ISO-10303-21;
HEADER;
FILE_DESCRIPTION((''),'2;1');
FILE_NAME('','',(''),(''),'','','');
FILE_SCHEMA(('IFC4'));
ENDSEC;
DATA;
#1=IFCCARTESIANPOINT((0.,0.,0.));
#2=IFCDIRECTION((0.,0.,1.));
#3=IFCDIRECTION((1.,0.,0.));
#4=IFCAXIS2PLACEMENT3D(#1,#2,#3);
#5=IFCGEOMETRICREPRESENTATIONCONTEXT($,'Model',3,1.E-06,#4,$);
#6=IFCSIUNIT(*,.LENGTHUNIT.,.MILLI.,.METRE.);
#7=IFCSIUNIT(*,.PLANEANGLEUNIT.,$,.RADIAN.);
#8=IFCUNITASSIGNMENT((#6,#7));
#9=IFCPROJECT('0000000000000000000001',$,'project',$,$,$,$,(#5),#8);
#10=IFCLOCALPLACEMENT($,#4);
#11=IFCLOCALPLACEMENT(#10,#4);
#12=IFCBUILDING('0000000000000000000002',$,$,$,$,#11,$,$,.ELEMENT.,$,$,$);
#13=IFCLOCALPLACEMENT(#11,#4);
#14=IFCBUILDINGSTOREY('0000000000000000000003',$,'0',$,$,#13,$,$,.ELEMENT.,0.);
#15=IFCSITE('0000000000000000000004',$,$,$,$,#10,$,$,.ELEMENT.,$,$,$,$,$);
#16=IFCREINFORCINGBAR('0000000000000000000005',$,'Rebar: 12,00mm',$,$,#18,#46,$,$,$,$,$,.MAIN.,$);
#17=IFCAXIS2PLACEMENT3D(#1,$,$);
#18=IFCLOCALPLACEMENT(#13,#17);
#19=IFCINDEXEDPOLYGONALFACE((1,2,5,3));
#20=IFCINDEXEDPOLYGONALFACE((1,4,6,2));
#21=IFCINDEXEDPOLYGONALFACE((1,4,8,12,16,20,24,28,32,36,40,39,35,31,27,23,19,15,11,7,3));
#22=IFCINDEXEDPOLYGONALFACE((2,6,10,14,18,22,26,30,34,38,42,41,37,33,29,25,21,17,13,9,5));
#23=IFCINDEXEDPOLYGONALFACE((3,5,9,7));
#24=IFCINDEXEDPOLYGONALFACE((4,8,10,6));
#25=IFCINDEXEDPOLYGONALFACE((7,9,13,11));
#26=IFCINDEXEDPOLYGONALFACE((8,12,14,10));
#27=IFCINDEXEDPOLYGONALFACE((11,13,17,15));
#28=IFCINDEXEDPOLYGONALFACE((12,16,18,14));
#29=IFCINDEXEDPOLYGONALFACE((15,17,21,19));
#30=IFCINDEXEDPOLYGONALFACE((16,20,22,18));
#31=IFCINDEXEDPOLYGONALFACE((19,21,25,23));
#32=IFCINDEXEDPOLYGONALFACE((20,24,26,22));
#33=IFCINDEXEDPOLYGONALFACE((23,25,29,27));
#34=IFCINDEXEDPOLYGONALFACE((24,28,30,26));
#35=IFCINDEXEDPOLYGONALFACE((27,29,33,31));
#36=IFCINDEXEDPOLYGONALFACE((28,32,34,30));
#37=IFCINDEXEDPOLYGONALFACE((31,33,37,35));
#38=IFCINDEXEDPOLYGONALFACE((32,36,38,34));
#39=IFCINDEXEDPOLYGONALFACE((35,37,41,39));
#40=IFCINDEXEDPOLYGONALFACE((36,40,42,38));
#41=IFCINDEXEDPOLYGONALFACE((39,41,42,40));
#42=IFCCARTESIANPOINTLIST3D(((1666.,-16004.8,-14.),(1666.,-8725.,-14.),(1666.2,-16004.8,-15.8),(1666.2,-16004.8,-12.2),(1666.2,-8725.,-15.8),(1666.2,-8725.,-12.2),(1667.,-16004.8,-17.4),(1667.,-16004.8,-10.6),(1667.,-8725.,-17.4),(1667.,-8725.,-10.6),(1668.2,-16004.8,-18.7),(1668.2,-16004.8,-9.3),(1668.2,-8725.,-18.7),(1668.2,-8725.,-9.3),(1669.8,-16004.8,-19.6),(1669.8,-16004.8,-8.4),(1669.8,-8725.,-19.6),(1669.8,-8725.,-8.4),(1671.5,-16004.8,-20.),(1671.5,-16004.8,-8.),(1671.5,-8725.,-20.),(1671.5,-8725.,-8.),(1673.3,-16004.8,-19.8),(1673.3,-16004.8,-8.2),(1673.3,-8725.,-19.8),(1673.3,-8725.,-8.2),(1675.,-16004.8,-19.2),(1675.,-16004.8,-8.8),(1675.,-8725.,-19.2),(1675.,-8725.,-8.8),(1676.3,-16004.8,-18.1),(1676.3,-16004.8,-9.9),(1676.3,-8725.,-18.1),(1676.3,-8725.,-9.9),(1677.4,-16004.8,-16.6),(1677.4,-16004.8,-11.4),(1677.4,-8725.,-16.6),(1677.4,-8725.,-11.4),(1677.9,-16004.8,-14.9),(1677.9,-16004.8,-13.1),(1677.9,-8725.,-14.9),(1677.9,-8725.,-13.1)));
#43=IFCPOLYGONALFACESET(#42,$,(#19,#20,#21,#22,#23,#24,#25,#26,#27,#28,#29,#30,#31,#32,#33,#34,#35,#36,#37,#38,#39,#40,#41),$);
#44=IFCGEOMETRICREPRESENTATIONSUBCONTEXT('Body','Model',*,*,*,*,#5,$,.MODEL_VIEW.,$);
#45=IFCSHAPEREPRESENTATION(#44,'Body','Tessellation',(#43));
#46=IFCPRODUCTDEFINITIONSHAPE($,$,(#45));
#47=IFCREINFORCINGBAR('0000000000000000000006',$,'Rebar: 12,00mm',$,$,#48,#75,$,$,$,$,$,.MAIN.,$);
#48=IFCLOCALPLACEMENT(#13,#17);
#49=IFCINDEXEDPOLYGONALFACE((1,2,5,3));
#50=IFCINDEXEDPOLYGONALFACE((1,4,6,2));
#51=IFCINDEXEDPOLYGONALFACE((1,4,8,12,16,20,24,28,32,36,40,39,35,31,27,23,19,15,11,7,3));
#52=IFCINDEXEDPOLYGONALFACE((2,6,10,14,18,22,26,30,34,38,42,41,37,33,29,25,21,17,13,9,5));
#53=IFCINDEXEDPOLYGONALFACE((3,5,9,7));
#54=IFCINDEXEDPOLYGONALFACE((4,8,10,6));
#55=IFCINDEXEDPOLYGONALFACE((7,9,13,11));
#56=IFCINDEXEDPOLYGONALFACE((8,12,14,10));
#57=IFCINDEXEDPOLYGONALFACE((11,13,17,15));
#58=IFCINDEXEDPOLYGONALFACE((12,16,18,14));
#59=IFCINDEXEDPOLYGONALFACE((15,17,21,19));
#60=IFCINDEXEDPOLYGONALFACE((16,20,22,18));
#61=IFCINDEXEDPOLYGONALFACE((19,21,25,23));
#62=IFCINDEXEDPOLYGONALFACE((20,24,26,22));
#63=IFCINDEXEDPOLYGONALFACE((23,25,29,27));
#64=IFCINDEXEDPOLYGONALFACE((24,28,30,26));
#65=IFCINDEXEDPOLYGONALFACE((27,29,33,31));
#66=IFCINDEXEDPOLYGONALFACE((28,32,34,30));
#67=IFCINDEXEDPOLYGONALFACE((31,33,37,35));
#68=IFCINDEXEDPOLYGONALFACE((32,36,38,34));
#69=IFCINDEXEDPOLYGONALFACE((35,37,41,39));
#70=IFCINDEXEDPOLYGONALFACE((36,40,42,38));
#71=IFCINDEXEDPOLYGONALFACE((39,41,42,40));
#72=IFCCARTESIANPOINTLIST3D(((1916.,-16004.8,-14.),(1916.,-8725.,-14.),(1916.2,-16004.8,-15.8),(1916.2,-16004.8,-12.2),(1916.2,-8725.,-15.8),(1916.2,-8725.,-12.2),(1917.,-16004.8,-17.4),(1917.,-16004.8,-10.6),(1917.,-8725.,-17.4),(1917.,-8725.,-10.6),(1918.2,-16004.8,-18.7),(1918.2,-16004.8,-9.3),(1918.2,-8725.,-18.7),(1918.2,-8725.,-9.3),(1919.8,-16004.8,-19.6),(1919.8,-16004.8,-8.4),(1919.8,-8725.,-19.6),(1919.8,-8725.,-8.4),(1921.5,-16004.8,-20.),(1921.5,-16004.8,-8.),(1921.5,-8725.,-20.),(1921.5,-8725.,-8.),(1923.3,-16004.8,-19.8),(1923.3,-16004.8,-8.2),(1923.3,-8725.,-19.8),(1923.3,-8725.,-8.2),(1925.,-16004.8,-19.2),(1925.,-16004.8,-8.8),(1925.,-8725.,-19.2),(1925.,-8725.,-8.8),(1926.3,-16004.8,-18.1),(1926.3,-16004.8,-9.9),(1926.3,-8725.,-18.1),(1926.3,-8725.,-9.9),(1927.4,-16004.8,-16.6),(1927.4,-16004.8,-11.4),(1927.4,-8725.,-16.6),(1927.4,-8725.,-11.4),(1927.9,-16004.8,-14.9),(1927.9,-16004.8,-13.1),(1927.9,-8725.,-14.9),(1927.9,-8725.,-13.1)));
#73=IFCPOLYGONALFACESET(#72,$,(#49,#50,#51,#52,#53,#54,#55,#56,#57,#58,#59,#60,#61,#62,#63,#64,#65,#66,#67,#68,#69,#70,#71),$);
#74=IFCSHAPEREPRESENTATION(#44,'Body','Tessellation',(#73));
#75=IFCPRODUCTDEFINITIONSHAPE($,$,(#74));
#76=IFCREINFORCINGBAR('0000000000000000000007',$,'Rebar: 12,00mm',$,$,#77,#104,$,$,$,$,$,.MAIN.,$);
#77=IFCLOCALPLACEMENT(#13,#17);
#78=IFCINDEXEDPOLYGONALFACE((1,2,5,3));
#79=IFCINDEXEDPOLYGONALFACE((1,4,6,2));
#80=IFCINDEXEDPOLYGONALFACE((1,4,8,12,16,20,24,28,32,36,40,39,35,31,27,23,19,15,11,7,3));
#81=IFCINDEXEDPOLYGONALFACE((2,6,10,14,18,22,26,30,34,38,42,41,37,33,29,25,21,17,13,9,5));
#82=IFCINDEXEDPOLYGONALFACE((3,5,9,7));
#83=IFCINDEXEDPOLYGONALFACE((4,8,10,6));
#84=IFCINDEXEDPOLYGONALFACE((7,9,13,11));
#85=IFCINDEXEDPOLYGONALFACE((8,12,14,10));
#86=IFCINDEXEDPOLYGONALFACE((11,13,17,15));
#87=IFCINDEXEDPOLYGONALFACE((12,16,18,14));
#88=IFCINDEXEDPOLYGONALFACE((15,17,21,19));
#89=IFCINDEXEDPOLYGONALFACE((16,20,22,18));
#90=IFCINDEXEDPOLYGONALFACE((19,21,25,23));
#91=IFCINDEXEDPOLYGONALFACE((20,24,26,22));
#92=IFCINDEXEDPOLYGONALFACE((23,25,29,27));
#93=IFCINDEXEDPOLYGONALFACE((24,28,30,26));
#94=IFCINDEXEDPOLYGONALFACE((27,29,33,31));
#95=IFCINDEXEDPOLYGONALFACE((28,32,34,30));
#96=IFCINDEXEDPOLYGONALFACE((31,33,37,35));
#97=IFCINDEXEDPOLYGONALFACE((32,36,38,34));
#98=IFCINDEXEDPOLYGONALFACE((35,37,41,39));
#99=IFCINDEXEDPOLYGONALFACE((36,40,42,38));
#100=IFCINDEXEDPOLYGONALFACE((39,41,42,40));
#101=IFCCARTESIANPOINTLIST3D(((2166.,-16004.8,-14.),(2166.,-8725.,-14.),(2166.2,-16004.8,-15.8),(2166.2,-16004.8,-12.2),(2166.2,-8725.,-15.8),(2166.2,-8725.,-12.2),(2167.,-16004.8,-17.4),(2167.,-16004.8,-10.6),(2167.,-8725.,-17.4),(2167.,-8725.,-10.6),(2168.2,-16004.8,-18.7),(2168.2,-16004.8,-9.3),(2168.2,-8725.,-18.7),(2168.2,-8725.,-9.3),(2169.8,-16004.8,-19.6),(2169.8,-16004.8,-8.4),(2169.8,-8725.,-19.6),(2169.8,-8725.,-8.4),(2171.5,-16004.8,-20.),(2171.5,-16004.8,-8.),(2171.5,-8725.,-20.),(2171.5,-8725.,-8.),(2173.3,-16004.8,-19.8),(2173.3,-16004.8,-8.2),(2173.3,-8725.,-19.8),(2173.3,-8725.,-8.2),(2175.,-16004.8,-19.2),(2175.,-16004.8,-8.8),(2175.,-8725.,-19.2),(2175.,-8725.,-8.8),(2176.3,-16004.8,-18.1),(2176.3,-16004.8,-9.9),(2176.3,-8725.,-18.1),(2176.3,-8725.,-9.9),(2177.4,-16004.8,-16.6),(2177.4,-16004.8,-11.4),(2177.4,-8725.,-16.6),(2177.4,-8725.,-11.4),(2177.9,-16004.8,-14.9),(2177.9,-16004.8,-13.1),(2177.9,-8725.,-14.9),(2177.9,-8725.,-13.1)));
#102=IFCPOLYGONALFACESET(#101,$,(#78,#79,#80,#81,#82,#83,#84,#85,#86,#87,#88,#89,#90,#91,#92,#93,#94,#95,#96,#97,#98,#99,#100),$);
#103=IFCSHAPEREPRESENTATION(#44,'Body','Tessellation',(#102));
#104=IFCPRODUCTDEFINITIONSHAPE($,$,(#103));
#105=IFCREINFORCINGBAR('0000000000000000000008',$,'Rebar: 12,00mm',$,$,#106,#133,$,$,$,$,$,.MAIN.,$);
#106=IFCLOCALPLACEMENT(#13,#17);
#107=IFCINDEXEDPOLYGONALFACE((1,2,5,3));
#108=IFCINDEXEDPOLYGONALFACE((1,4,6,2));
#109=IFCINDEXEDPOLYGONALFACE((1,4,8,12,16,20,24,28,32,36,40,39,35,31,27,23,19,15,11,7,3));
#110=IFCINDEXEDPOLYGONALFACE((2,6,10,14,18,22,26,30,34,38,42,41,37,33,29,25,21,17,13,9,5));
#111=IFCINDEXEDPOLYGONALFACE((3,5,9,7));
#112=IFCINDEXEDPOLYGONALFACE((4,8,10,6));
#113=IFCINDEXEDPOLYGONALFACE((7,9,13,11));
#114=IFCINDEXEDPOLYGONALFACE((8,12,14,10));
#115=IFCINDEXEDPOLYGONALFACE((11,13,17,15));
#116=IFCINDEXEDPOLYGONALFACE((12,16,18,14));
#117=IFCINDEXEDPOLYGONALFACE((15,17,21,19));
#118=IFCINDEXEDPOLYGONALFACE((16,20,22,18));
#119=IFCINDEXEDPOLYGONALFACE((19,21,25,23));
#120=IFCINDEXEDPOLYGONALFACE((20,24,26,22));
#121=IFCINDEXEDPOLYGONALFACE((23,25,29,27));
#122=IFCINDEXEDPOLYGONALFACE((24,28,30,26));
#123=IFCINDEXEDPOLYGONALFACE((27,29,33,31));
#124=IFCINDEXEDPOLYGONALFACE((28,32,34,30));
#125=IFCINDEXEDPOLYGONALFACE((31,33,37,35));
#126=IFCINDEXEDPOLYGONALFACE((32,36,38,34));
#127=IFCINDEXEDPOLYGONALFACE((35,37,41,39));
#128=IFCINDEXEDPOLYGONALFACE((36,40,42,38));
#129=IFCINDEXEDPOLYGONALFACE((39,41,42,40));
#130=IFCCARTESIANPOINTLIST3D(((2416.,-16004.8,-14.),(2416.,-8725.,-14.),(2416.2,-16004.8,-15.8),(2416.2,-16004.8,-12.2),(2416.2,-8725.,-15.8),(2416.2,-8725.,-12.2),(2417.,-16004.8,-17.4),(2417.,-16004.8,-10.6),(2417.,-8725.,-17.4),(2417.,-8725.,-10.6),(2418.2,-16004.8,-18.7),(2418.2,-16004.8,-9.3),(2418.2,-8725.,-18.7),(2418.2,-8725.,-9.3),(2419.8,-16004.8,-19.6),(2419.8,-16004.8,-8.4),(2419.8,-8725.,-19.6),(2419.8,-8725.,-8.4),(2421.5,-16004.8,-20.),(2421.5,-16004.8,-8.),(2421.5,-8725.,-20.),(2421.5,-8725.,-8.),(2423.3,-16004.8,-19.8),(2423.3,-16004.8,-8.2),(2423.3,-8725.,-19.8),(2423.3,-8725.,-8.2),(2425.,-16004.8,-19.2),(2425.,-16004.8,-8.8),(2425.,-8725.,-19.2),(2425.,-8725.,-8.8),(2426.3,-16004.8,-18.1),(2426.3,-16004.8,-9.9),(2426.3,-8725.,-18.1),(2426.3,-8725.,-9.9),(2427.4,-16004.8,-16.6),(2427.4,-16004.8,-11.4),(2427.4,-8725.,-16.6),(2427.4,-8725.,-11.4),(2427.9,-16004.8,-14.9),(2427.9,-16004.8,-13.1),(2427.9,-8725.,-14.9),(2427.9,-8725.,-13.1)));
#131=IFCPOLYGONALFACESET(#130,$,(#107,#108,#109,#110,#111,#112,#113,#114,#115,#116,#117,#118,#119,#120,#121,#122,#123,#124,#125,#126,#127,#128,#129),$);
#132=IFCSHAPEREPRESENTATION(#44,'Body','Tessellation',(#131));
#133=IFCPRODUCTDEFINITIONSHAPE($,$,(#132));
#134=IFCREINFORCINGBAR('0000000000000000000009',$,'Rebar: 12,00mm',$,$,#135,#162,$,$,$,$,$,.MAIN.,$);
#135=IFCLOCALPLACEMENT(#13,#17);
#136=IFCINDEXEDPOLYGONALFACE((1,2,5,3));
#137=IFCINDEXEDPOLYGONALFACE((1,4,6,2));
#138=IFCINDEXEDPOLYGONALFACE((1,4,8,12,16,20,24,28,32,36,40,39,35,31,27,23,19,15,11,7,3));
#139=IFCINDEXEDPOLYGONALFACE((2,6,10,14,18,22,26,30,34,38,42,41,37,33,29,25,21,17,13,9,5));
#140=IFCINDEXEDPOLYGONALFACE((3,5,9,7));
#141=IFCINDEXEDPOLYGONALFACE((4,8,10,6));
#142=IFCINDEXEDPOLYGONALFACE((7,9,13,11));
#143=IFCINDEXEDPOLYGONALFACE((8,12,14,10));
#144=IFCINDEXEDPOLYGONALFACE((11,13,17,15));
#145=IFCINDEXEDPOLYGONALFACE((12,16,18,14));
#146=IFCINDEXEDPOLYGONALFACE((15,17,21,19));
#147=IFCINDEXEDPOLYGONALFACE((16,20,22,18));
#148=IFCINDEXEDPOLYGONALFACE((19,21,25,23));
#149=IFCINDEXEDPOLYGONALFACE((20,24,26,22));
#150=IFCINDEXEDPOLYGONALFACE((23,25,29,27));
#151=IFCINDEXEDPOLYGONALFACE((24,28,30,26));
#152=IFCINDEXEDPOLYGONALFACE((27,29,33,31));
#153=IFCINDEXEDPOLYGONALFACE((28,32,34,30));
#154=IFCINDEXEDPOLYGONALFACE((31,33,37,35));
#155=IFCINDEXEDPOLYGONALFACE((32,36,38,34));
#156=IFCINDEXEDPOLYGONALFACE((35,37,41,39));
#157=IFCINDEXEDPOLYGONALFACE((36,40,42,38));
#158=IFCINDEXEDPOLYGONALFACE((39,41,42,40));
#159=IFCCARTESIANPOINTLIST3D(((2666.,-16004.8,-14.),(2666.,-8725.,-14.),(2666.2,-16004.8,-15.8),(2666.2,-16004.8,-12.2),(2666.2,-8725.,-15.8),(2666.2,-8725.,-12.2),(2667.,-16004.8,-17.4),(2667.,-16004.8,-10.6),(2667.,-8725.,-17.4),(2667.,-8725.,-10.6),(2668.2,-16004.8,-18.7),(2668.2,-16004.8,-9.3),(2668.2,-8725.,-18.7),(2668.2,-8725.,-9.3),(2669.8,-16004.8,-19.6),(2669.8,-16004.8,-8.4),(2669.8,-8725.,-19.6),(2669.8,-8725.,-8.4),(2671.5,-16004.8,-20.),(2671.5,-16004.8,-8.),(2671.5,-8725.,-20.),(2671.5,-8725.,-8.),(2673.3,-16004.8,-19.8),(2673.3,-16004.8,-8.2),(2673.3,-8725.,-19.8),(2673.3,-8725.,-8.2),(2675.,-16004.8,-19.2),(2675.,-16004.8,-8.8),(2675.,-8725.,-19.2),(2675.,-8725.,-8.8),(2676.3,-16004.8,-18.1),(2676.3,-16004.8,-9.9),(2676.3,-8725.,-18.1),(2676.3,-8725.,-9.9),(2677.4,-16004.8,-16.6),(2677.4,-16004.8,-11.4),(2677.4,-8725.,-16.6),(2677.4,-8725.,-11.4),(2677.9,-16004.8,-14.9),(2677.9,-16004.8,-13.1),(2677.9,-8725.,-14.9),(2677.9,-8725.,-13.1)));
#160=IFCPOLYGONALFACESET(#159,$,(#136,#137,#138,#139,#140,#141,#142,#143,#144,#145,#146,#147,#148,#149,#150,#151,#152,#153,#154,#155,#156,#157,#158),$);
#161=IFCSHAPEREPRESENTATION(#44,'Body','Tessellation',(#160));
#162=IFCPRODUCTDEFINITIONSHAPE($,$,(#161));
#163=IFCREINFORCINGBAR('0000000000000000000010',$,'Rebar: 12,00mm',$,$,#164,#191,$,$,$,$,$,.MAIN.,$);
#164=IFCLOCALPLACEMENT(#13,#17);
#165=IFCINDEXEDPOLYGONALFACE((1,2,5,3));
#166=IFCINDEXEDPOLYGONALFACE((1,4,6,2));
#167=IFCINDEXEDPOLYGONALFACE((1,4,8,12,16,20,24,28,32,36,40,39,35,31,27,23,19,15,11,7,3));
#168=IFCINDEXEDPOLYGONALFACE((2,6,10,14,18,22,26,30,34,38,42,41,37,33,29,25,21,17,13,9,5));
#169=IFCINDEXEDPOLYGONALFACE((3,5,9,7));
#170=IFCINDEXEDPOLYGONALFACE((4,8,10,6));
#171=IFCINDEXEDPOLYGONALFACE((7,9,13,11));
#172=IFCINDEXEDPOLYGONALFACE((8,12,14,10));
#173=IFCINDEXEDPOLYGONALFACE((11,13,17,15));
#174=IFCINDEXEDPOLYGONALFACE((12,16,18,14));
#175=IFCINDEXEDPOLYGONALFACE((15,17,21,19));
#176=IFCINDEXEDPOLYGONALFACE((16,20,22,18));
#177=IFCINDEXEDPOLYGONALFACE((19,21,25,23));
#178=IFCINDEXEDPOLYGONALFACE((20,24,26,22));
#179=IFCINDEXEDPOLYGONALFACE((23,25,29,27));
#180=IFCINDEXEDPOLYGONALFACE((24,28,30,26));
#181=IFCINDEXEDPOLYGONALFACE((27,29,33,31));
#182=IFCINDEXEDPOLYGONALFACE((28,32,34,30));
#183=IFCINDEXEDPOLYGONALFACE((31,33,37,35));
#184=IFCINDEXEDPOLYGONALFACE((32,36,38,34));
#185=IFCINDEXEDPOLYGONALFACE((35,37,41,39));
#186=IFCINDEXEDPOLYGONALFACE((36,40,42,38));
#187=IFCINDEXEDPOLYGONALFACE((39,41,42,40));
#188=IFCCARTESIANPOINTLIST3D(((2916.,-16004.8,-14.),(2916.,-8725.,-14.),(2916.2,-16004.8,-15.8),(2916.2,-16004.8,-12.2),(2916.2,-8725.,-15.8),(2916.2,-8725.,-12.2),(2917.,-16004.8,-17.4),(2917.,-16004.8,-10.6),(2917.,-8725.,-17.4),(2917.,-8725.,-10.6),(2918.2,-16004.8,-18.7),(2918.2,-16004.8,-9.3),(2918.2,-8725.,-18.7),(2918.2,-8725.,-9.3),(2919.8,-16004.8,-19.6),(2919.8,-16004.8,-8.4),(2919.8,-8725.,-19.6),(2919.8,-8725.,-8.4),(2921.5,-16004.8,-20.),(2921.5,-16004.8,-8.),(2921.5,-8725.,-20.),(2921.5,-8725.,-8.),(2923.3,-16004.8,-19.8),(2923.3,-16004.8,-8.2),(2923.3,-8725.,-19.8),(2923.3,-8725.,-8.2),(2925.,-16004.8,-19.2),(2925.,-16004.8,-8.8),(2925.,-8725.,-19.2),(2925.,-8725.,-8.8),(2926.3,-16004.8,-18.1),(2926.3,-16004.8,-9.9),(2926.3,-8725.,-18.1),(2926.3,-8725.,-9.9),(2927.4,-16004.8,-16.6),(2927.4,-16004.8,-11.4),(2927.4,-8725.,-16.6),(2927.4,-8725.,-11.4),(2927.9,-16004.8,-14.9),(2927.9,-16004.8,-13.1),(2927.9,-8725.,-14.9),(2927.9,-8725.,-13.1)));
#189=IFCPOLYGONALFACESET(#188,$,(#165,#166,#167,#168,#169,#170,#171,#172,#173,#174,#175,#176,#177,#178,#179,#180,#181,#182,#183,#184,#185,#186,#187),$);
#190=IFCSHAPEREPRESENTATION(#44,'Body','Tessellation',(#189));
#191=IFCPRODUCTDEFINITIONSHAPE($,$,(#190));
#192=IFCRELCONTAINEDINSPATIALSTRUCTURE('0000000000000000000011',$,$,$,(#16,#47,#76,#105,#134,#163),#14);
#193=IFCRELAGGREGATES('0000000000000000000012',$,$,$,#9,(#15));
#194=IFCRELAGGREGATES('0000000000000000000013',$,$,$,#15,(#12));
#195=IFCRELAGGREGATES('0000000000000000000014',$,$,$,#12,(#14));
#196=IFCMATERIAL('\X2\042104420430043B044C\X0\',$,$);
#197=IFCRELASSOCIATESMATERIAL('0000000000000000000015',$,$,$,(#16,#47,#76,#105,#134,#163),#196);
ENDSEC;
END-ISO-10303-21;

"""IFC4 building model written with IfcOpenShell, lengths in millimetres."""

from ifc_helpers import new_model, entity, si_unit, origin_with_axes, place, context, subcontext, project, spatial, source, transform, mapped, material, element, save


model = new_model("IFC4")

# Units and contexts
model_context = context("Model", 3, precision=1e-06, world=origin_with_axes())
body_context = subcontext(model_context, "Body", "Model", "MODEL_VIEW")
ifc_project = project(units=[si_unit("LENGTHUNIT", "METRE", prefix="MILLI"), si_unit("PLANEANGLEUNIT", "RADIAN")], contexts=[model_context])

# Site, building, storey
site_placement = place(None, origin_with_axes())
site = spatial("IfcSite", under=ifc_project, at=site_placement, CompositionType="ELEMENT")
building_placement = place(site_placement, origin_with_axes())
building = spatial("IfcBuilding", under=site, at=building_placement, CompositionType="ELEMENT")
storey_placement = place(building_placement, origin_with_axes())
storey = spatial("IfcBuildingStorey", under=building, at=storey_placement, Name="0", CompositionType="ELEMENT", Elevation=0.0)

# Reinforcing bars
ifc_material = material(Name="Сталь")
shared_shape = source(origin_with_axes(), body_context, "Body", "AdvancedSweptSolid", [
    entity("IfcSweptDiskSolid", entity("IfcIndexedPolyCurve", entity("IfcCartesianPointList3D", [[0.0, 0.0, 0.0], [7279.8, 0.0, 0.0]]), [entity("IfcLineIndex", [1, 2])]), 6.0),
])
reinforcing_bar_1_placement = place(storey_placement, origin_with_axes())
element("IfcReinforcingBar", 1, at=reinforcing_bar_1_placement, inside=storey, material=ifc_material, Name="Rebar: 12,00mm", PredefinedType="MAIN", context=body_context, shape_type="MappedRepresentation", body=[
    mapped(shared_shape, transform((1672.0, -16004.8, -14.0), x_axis=(0.0, 1.0, 0.0), y_axis=(-1.0, 0.0, 0.0), z_axis=(0.0, 0.0, 1.0), scale=1.0)),
])
reinforcing_bar_2_placement = place(storey_placement, origin_with_axes())
element("IfcReinforcingBar", 2, at=reinforcing_bar_2_placement, inside=storey, material=ifc_material, Name="Rebar: 12,00mm", PredefinedType="MAIN", context=body_context, shape_type="MappedRepresentation", body=[
    mapped(shared_shape, transform((1922.0, -16004.8, -14.0), x_axis=(0.0, 1.0, 0.0), y_axis=(-1.0, 0.0, 0.0), z_axis=(0.0, 0.0, 1.0), scale=1.0)),
])
reinforcing_bar_3_placement = place(storey_placement, origin_with_axes())
element("IfcReinforcingBar", 3, at=reinforcing_bar_3_placement, inside=storey, material=ifc_material, Name="Rebar: 12,00mm", PredefinedType="MAIN", context=body_context, shape_type="MappedRepresentation", body=[
    mapped(shared_shape, transform((2172.0, -16004.8, -14.0), x_axis=(0.0, 1.0, 0.0), y_axis=(-1.0, 0.0, 0.0), z_axis=(0.0, 0.0, 1.0), scale=1.0)),
])
reinforcing_bar_4_placement = place(storey_placement, origin_with_axes())
element("IfcReinforcingBar", 4, at=reinforcing_bar_4_placement, inside=storey, material=ifc_material, Name="Rebar: 12,00mm", PredefinedType="MAIN", context=body_context, shape_type="MappedRepresentation", body=[
    mapped(shared_shape, transform((2422.0, -16004.8, -14.0), x_axis=(0.0, 1.0, 0.0), y_axis=(-1.0, 0.0, 0.0), z_axis=(0.0, 0.0, 1.0), scale=1.0)),
])
reinforcing_bar_5_placement = place(storey_placement, origin_with_axes())
element("IfcReinforcingBar", 5, at=reinforcing_bar_5_placement, inside=storey, material=ifc_material, Name="Rebar: 12,00mm", PredefinedType="MAIN", context=body_context, shape_type="MappedRepresentation", body=[
    mapped(shared_shape, transform((2672.0, -16004.8, -14.0), x_axis=(0.0, 1.0, 0.0), y_axis=(-1.0, 0.0, 0.0), z_axis=(0.0, 0.0, 1.0), scale=1.0)),
])
reinforcing_bar_6_placement = place(storey_placement, origin_with_axes())
element("IfcReinforcingBar", 6, at=reinforcing_bar_6_placement, inside=storey, material=ifc_material, Name="Rebar: 12,00mm", PredefinedType="MAIN", context=body_context, shape_type="MappedRepresentation", body=[
    mapped(shared_shape, transform((2922.0, -16004.8, -14.0), x_axis=(0.0, 1.0, 0.0), y_axis=(-1.0, 0.0, 0.0), z_axis=(0.0, 0.0, 1.0), scale=1.0)),
])

save(model, "model.ifc")
